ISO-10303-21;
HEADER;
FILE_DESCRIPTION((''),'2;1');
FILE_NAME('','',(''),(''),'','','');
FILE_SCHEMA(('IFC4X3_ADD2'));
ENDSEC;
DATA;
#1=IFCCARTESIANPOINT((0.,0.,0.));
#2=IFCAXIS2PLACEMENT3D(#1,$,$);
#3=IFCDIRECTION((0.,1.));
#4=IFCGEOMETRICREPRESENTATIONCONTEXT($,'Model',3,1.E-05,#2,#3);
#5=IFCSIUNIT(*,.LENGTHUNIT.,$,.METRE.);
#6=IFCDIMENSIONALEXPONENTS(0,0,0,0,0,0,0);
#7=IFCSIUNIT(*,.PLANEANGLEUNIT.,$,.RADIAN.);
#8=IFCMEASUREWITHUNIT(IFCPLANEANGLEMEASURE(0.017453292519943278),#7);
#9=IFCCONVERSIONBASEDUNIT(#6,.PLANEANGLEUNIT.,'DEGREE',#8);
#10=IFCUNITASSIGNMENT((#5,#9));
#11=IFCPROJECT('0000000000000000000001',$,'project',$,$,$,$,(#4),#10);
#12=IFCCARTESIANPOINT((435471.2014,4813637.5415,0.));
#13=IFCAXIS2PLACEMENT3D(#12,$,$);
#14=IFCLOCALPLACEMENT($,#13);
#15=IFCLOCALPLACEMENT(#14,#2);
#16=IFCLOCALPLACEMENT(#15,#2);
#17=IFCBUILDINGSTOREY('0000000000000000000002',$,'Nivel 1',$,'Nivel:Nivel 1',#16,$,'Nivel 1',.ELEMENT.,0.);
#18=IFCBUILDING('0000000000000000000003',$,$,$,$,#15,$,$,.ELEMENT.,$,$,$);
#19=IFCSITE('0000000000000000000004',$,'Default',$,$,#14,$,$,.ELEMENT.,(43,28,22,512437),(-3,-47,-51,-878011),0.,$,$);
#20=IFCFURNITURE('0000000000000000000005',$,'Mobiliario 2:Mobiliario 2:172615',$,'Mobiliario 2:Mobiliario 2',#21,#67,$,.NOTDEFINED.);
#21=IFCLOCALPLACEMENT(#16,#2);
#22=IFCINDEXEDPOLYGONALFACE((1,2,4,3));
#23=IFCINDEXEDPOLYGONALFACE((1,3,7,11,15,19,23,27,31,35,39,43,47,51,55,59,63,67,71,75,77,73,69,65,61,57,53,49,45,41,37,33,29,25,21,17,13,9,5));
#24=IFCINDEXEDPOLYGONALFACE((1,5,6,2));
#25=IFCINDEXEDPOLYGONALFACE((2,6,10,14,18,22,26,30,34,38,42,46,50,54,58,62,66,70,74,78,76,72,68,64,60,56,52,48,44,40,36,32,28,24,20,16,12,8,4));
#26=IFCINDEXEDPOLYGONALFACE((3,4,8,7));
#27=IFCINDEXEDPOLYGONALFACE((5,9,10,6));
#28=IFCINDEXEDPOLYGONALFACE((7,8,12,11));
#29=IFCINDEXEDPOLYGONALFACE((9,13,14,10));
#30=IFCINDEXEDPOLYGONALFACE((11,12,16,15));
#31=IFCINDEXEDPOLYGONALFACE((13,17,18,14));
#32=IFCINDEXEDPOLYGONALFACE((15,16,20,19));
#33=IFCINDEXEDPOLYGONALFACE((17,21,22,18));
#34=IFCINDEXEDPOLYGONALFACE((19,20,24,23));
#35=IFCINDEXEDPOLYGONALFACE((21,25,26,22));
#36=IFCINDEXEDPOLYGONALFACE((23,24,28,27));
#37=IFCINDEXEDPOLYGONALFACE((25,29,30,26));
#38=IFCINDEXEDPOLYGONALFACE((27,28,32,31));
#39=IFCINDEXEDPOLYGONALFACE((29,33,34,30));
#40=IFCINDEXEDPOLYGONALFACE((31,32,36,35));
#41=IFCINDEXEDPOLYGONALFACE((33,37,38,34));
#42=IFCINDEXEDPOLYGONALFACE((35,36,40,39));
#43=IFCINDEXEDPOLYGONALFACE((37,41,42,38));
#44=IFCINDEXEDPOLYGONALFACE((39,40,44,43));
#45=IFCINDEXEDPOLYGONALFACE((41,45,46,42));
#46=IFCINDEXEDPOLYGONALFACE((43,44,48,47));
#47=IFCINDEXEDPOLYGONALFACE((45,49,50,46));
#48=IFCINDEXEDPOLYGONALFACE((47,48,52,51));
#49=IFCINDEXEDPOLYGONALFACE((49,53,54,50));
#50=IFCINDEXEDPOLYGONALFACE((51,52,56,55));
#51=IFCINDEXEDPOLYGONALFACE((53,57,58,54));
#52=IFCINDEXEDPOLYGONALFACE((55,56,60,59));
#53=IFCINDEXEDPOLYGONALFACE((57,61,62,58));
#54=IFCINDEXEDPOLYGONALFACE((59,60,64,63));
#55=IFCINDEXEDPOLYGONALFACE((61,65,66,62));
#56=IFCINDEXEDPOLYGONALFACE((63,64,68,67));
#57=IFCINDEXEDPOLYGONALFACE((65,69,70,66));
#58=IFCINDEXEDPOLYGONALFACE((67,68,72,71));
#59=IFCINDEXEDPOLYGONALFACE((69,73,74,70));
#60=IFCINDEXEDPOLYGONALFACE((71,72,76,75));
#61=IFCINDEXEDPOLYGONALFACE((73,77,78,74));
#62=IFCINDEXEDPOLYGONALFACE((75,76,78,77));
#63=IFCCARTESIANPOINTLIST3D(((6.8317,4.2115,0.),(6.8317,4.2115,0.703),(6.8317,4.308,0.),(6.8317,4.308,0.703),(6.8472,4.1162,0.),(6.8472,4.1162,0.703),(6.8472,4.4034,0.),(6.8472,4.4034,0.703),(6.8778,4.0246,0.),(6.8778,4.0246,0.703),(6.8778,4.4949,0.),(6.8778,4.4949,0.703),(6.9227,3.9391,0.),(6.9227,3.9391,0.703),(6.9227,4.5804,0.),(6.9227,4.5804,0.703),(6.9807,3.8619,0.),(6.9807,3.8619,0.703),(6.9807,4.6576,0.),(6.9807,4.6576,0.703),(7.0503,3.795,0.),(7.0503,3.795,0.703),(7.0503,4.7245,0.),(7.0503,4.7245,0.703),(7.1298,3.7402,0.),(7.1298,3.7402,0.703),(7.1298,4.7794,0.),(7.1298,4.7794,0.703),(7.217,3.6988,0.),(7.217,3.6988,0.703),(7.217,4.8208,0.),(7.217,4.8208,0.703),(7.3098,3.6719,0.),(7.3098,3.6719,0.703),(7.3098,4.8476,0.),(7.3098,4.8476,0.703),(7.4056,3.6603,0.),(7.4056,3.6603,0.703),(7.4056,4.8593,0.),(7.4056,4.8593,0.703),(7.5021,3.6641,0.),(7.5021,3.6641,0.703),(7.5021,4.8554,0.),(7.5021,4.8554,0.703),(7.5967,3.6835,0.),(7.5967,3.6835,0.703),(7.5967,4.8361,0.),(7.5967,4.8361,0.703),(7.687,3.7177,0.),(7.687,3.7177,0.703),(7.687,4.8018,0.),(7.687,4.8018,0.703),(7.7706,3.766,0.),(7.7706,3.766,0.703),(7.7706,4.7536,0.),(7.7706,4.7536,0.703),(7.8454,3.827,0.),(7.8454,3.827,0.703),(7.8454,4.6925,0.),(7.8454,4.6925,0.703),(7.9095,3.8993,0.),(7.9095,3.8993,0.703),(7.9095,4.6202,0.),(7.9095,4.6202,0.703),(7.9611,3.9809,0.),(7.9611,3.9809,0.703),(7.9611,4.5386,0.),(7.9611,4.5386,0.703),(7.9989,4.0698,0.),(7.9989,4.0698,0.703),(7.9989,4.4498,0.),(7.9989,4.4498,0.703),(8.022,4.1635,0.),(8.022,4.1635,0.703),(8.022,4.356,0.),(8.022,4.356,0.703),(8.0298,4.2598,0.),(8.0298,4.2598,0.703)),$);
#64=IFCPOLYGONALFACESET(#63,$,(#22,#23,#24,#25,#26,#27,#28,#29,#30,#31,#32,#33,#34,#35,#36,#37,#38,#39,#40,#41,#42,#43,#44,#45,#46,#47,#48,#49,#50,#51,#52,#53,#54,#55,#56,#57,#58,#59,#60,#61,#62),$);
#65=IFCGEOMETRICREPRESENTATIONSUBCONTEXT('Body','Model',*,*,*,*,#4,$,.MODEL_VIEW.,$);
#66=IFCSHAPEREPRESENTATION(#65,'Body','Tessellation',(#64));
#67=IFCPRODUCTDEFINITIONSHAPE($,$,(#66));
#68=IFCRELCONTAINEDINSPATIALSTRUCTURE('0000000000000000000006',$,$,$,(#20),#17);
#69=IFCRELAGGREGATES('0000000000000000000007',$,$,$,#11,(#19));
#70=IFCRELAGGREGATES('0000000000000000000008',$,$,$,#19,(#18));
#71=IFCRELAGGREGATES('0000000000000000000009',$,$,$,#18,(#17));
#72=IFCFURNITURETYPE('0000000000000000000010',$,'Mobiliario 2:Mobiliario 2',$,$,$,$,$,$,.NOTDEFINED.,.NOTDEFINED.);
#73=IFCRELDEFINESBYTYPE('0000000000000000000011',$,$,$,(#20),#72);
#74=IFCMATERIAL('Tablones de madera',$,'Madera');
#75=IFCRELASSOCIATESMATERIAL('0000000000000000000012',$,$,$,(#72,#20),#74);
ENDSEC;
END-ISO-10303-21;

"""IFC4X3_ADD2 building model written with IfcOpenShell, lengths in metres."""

from ifc_helpers import new_model, entity, si_unit, converted_unit, direction, frame, frame_2d, origin, place, context, subcontext, project, spatial, circle, extrude, source, transform, mapped, material, type_object, type_shapes, element, save


model = new_model("IFC4X3_ADD2")

# Units and contexts
model_context = context("Model", 3, precision=1e-05, world=origin(), true_north=direction((0.0, 1.0)))
body_context = subcontext(model_context, "Body", "Model", "MODEL_VIEW")
ifc_project = project(units=[si_unit("LENGTHUNIT", "METRE"), converted_unit("PLANEANGLEUNIT", "DEGREE", entity("IfcPlaneAngleMeasure", 0.017453292519943278), si_unit("PLANEANGLEUNIT", "RADIAN"), dimensions=[0, 0, 0, 0, 0, 0, 0])], contexts=[model_context])

# Site, building, storey
site_placement = place(None, frame((435471.2014, 4813637.5415, 0.0)))
site = spatial("IfcSite", under=ifc_project, at=site_placement, Name="Default", CompositionType="ELEMENT", RefLatitude=(43, 28, 22, 512437), RefLongitude=(-3, -47, -51, -878011), RefElevation=0.0)
building_placement = place(site_placement, origin())
building = spatial("IfcBuilding", under=site, at=building_placement, CompositionType="ELEMENT")
storey_placement = place(building_placement, origin())
storey = spatial("IfcBuildingStorey", under=building, at=storey_placement, Name="Nivel 1", ObjectType="Nivel:Nivel 1", LongName="Nivel 1", CompositionType="ELEMENT", Elevation=0.0)

# Furniture
ifc_material_1 = material(Name="Tablones de madera", Category="Madera")
furniture_type_1 = type_object("IfcFurnitureType", Name="Mobiliario 2:Mobiliario 2", AssemblyPlace="NOTDEFINED", PredefinedType="NOTDEFINED", material=ifc_material_1)
shared_shape_1 = source(origin(), body_context, "Body", "SweptSolid", [
    extrude(circle(Radius=0.6, at=frame_2d((0.0, 0.0), x_axis=(1.0, 0.0))), frame((7.4298, 4.2598, 0.0)), (0.0, 0.0, 1.0), 0.703),
])
type_shapes(furniture_type_1, [shared_shape_1])
furniture_1_placement = place(storey_placement, origin())
element("IfcFurniture", 1, at=furniture_1_placement, inside=storey, type_object=furniture_type_1, material=ifc_material_1, Name="Mobiliario 2:Mobiliario 2:172615", ObjectType="Mobiliario 2:Mobiliario 2", PredefinedType="NOTDEFINED", context=body_context, shape_type="MappedRepresentation", body=[
    mapped(shared_shape_1, transform((0.0, 0.0, 0.0), scale=1.0)),
])

save(model, "model.ifc")
